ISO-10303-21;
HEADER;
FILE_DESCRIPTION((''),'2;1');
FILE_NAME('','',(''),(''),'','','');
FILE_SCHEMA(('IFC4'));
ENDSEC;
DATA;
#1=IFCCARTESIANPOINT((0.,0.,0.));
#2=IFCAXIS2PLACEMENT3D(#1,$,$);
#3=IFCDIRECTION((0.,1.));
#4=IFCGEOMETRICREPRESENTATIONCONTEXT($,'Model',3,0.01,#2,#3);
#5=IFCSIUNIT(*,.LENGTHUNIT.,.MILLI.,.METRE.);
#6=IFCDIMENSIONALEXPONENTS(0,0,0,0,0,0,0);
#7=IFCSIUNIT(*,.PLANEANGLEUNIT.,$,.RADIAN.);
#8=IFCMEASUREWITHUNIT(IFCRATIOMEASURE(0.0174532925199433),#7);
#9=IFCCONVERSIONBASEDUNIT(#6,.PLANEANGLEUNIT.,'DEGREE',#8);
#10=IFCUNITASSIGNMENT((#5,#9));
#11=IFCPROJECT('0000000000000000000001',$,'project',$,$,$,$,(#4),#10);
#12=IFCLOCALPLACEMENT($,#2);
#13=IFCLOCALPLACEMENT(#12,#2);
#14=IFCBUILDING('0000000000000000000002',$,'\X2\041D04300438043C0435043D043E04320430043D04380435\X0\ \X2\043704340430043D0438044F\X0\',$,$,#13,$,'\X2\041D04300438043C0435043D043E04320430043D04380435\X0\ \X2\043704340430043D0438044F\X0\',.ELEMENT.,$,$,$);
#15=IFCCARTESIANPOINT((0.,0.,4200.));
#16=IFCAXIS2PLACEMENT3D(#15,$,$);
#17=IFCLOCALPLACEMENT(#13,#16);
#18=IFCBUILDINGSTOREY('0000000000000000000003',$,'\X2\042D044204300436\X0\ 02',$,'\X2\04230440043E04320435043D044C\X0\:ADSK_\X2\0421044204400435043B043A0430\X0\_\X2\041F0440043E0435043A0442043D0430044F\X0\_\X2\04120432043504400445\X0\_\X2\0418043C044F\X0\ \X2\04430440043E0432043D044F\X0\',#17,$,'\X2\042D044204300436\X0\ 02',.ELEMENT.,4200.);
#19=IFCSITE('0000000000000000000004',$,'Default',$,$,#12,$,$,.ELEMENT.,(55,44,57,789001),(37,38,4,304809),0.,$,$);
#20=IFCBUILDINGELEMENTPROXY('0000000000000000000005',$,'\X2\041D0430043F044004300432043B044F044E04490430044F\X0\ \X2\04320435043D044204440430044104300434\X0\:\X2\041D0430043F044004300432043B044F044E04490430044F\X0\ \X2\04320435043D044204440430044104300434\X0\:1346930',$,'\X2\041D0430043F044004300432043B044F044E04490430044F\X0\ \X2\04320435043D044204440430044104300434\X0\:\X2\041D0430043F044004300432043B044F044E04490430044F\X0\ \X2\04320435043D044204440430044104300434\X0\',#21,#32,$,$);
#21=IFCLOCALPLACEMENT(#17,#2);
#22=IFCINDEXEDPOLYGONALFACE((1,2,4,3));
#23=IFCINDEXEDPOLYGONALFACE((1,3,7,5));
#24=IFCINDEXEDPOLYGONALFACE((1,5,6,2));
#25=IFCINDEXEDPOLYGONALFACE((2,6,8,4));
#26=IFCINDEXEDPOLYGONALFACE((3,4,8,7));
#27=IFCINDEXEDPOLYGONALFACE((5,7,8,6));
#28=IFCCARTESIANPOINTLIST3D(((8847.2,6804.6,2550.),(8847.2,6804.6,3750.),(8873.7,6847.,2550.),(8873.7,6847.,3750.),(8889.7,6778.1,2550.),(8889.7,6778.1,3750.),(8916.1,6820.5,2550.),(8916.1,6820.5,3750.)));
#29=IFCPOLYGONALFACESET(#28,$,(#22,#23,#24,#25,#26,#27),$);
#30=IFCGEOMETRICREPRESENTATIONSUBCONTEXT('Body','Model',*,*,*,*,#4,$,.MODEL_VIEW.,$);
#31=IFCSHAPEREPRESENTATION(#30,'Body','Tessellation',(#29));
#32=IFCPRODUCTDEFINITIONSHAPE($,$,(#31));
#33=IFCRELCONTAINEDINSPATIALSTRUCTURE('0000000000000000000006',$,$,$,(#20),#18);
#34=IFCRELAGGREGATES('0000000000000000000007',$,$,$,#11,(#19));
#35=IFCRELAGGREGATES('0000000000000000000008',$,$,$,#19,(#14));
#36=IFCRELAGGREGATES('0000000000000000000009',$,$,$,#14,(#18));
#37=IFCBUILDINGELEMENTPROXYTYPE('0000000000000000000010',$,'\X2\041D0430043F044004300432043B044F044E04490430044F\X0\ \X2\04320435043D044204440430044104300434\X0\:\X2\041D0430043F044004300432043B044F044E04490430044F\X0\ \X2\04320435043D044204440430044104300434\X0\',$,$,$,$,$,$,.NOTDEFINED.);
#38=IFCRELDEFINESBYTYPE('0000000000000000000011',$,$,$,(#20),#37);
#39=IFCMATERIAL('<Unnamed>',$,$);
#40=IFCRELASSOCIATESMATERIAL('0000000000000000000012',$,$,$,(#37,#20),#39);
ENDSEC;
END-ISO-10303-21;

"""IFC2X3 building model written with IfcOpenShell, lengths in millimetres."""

from ifc_helpers import new_model, entity, si_unit, converted_unit, direction, frame, origin, origin_2d_with_axis, place, context, subcontext, project, spatial, rectangle, extrude, source, transform, mapped, material, type_object, type_shapes, element, save


model = new_model("IFC2X3")

# Units and contexts
model_context = context("Model", 3, precision=0.01, world=origin(), true_north=direction((0.0, 1.0)))
body_context = subcontext(model_context, "Body", "Model", "MODEL_VIEW")
ifc_project = project(units=[si_unit("LENGTHUNIT", "METRE", prefix="MILLI"), converted_unit("PLANEANGLEUNIT", "DEGREE", entity("IfcRatioMeasure", 0.0174532925199433), si_unit("PLANEANGLEUNIT", "RADIAN"), dimensions=[0, 0, 0, 0, 0, 0, 0])], contexts=[model_context])

# Site, building, storey
site_placement = place(None, origin())
site = spatial("IfcSite", under=ifc_project, at=site_placement, Name="Default", CompositionType="ELEMENT", RefLatitude=(55, 44, 57, 789001), RefLongitude=(37, 38, 4, 304809), RefElevation=0.0)
building_placement = place(site_placement, origin())
building = spatial("IfcBuilding", under=site, at=building_placement, Name="Наименование здания", LongName="Наименование здания", CompositionType="ELEMENT")
storey_placement = place(building_placement, frame((0.0, 0.0, 4200.0)))
storey = spatial("IfcBuildingStorey", under=building, at=storey_placement, Name="Этаж 02", ObjectType="Уровень:ADSK_Стрелка_Проектная_Вверх_Имя уровня", LongName="Этаж 02", CompositionType="ELEMENT", Elevation=4200.0)

# Building element proxy
ifc_material_1 = material(Name="<Unnamed>")
building_element_proxy_type_1 = type_object("IfcBuildingElementProxyType", Name="Направляющая вентфасад:Направляющая вентфасад", PredefinedType="NOTDEFINED", material=ifc_material_1)
shared_shape_1 = source(origin(), body_context, "Body", "SweptSolid", [
    extrude(rectangle(XDim=50.0, YDim=50.0, at=origin_2d_with_axis()), frame((25.0, -25.0, 0.0), z_axis=(0.0, 0.0, 1.0), x_axis=(-1.0, 0.0, 0.0)), (0.0, 0.0, 1.0), 1200.0),
])
type_shapes(building_element_proxy_type_1, [shared_shape_1])
proxy_1_placement = place(storey_placement, frame((8873.7, 6847.0, 2550.0), z_axis=(0.0, 0.0, 1.0), x_axis=(0.848053, -0.529912, 0.0)))
element("IfcBuildingElementProxy", 1, at=proxy_1_placement, inside=storey, type_object=building_element_proxy_type_1, material=ifc_material_1, Name="Направляющая вентфасад:Направляющая вентфасад:1346930", ObjectType="Направляющая вентфасад:Направляющая вентфасад", context=body_context, shape_type="MappedRepresentation", body=[
    mapped(shared_shape_1, transform((0.0, 0.0, 0.0), scale=1.0)),
])

save(model, "model.ifc")
